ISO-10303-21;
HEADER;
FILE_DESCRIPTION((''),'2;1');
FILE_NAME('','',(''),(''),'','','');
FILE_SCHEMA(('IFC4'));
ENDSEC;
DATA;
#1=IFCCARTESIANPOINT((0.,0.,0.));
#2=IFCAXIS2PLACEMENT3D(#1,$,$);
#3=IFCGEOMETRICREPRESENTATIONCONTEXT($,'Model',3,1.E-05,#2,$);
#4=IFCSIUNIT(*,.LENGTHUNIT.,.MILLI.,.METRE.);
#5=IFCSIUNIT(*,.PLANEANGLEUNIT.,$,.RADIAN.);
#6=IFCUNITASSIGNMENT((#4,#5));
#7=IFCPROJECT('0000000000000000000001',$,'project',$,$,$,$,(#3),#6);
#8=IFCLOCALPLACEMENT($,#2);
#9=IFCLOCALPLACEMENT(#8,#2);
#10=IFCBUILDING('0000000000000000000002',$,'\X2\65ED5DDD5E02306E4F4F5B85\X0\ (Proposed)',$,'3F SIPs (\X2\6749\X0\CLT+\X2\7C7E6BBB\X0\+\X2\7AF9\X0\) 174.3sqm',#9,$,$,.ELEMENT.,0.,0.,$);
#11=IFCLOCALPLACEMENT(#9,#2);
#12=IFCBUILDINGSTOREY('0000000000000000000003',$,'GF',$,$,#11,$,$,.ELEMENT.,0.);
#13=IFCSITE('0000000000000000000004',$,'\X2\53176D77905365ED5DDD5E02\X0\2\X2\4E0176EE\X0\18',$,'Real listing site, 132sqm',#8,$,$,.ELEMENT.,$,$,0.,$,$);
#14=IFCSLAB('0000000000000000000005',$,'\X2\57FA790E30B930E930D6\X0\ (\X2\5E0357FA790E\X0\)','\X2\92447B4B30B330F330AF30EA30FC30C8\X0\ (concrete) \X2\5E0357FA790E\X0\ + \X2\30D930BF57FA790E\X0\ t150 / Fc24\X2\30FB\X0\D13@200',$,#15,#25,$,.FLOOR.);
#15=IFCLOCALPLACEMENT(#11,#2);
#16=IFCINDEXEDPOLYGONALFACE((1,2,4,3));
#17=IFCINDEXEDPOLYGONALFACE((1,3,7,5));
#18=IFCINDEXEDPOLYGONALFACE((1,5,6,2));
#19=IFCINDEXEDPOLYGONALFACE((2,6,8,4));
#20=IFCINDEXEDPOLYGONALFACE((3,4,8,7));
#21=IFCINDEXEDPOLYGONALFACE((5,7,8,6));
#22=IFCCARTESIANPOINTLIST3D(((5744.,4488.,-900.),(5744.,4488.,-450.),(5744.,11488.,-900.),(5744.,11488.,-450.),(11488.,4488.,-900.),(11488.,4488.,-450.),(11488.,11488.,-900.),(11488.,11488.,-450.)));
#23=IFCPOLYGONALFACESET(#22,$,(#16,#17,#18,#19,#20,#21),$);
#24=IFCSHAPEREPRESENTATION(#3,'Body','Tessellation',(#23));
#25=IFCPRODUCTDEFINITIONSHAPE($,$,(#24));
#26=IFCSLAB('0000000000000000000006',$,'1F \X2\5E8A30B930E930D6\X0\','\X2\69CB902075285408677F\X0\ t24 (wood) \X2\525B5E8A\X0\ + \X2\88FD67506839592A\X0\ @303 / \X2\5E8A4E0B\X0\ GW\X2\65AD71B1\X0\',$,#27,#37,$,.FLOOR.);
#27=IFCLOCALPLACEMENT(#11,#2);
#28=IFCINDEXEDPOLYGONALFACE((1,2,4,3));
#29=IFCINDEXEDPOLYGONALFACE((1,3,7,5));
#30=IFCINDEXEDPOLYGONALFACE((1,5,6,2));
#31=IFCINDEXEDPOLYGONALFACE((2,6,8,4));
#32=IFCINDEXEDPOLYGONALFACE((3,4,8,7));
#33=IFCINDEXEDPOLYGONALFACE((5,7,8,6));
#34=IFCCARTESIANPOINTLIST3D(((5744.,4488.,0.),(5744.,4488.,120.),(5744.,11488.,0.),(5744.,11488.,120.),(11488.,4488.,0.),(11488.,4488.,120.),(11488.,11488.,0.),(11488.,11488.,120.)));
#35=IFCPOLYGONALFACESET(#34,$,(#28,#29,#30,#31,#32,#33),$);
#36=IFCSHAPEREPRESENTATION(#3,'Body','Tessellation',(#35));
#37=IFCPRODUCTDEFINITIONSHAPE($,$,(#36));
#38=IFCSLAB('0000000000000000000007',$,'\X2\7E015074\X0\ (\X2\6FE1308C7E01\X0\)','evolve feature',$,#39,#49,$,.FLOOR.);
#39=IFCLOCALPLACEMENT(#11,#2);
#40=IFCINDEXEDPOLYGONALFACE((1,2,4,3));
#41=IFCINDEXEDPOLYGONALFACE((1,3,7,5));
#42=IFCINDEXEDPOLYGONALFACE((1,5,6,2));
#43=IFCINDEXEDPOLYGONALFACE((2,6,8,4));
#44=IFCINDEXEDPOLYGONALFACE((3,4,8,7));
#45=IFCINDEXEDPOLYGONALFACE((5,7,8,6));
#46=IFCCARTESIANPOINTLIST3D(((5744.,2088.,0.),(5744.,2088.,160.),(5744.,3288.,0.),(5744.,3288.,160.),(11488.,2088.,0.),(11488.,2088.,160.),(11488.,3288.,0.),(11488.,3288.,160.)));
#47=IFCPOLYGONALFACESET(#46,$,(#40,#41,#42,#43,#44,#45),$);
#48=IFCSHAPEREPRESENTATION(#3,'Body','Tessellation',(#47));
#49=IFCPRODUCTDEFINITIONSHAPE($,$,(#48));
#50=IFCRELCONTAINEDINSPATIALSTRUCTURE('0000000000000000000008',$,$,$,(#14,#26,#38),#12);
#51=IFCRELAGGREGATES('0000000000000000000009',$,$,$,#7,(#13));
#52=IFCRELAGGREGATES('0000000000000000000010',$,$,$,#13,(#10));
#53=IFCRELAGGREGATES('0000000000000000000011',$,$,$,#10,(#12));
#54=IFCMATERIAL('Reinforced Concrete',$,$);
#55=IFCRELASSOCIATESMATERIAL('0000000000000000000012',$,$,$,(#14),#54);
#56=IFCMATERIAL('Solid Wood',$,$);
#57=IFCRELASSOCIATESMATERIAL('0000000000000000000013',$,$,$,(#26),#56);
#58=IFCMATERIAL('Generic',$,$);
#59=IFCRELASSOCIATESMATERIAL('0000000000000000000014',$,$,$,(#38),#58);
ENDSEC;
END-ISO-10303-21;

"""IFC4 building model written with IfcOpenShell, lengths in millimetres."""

from ifc_helpers import new_model, si_unit, frame, frame_2d, origin, place, context, project, spatial, rectangle, extrude, material, element, save


model = new_model("IFC4")

# Units and contexts
model_context = context("Model", 3, precision=1e-05, world=origin())
ifc_project = project(units=[si_unit("LENGTHUNIT", "METRE", prefix="MILLI"), si_unit("PLANEANGLEUNIT", "RADIAN")], contexts=[model_context])

# Site, building, storey
site_placement = place(None, origin())
site = spatial("IfcSite", under=ifc_project, at=site_placement, Name="北海道旭川市2丁目18", ObjectType="Real listing site, 132sqm", CompositionType="ELEMENT", RefElevation=0.0)
building_placement = place(site_placement, origin())
building = spatial("IfcBuilding", under=site, at=building_placement, Name="旭川市の住宅 (Proposed)", ObjectType="3F SIPs (杉CLT+籾殻+竹) 174.3sqm", CompositionType="ELEMENT", ElevationOfRefHeight=0.0, ElevationOfTerrain=0.0)
storey_placement = place(building_placement, origin())
storey = spatial("IfcBuildingStorey", under=building, at=storey_placement, Name="GF", CompositionType="ELEMENT", Elevation=0.0)

# Slabs
ifc_material_1 = material(Name="Reinforced Concrete")
slab_1_placement = place(storey_placement, frame((2872.0, 2244.0, -450.0)))
element("IfcSlab", 1, at=slab_1_placement, inside=storey, material=ifc_material_1, Name="基礎スラブ (布基礎)", Description="鉄筋コンクリート (concrete) 布基礎 + ベタ基礎 t150 / Fc24・D13@200", PredefinedType="FLOOR", context=model_context, shape_type="SweptSolid", body=[
    extrude(rectangle(XDim=5744.0, YDim=7000.0, at=frame_2d((2872.0, 3500.0))), frame((2872.0, 2244.0, -450.0)), (0.0, 0.0, 1.0), 450.0),
])
ifc_material_2 = material(Name="Solid Wood")
slab_2_placement = place(storey_placement, frame((2872.0, 2244.0, 0.0)))
element("IfcSlab", 2, at=slab_2_placement, inside=storey, material=ifc_material_2, Name="1F 床スラブ", Description="構造用合板 t24 (wood) 剛床 + 製材根太 @303 / 床下 GW断熱", PredefinedType="FLOOR", context=model_context, shape_type="SweptSolid", body=[
    extrude(rectangle(XDim=5744.0, YDim=7000.0, at=frame_2d((2872.0, 3500.0))), frame((2872.0, 2244.0, 0.0)), (0.0, 0.0, 1.0), 120.0),
])
ifc_material_3 = material(Name="Generic")
slab_3_placement = place(storey_placement, frame((2872.0, 1044.0, 0.0)))
element("IfcSlab", 3, at=slab_3_placement, inside=storey, material=ifc_material_3, Name="縁側 (濡れ縁)", Description="evolve feature", PredefinedType="FLOOR", context=model_context, shape_type="SweptSolid", body=[
    extrude(rectangle(XDim=5744.0, YDim=1200.0, at=frame_2d((2872.0, 600.0))), frame((2872.0, 1044.0, 0.0)), (0.0, 0.0, 1.0), 160.0),
])

save(model, "model.ifc")
